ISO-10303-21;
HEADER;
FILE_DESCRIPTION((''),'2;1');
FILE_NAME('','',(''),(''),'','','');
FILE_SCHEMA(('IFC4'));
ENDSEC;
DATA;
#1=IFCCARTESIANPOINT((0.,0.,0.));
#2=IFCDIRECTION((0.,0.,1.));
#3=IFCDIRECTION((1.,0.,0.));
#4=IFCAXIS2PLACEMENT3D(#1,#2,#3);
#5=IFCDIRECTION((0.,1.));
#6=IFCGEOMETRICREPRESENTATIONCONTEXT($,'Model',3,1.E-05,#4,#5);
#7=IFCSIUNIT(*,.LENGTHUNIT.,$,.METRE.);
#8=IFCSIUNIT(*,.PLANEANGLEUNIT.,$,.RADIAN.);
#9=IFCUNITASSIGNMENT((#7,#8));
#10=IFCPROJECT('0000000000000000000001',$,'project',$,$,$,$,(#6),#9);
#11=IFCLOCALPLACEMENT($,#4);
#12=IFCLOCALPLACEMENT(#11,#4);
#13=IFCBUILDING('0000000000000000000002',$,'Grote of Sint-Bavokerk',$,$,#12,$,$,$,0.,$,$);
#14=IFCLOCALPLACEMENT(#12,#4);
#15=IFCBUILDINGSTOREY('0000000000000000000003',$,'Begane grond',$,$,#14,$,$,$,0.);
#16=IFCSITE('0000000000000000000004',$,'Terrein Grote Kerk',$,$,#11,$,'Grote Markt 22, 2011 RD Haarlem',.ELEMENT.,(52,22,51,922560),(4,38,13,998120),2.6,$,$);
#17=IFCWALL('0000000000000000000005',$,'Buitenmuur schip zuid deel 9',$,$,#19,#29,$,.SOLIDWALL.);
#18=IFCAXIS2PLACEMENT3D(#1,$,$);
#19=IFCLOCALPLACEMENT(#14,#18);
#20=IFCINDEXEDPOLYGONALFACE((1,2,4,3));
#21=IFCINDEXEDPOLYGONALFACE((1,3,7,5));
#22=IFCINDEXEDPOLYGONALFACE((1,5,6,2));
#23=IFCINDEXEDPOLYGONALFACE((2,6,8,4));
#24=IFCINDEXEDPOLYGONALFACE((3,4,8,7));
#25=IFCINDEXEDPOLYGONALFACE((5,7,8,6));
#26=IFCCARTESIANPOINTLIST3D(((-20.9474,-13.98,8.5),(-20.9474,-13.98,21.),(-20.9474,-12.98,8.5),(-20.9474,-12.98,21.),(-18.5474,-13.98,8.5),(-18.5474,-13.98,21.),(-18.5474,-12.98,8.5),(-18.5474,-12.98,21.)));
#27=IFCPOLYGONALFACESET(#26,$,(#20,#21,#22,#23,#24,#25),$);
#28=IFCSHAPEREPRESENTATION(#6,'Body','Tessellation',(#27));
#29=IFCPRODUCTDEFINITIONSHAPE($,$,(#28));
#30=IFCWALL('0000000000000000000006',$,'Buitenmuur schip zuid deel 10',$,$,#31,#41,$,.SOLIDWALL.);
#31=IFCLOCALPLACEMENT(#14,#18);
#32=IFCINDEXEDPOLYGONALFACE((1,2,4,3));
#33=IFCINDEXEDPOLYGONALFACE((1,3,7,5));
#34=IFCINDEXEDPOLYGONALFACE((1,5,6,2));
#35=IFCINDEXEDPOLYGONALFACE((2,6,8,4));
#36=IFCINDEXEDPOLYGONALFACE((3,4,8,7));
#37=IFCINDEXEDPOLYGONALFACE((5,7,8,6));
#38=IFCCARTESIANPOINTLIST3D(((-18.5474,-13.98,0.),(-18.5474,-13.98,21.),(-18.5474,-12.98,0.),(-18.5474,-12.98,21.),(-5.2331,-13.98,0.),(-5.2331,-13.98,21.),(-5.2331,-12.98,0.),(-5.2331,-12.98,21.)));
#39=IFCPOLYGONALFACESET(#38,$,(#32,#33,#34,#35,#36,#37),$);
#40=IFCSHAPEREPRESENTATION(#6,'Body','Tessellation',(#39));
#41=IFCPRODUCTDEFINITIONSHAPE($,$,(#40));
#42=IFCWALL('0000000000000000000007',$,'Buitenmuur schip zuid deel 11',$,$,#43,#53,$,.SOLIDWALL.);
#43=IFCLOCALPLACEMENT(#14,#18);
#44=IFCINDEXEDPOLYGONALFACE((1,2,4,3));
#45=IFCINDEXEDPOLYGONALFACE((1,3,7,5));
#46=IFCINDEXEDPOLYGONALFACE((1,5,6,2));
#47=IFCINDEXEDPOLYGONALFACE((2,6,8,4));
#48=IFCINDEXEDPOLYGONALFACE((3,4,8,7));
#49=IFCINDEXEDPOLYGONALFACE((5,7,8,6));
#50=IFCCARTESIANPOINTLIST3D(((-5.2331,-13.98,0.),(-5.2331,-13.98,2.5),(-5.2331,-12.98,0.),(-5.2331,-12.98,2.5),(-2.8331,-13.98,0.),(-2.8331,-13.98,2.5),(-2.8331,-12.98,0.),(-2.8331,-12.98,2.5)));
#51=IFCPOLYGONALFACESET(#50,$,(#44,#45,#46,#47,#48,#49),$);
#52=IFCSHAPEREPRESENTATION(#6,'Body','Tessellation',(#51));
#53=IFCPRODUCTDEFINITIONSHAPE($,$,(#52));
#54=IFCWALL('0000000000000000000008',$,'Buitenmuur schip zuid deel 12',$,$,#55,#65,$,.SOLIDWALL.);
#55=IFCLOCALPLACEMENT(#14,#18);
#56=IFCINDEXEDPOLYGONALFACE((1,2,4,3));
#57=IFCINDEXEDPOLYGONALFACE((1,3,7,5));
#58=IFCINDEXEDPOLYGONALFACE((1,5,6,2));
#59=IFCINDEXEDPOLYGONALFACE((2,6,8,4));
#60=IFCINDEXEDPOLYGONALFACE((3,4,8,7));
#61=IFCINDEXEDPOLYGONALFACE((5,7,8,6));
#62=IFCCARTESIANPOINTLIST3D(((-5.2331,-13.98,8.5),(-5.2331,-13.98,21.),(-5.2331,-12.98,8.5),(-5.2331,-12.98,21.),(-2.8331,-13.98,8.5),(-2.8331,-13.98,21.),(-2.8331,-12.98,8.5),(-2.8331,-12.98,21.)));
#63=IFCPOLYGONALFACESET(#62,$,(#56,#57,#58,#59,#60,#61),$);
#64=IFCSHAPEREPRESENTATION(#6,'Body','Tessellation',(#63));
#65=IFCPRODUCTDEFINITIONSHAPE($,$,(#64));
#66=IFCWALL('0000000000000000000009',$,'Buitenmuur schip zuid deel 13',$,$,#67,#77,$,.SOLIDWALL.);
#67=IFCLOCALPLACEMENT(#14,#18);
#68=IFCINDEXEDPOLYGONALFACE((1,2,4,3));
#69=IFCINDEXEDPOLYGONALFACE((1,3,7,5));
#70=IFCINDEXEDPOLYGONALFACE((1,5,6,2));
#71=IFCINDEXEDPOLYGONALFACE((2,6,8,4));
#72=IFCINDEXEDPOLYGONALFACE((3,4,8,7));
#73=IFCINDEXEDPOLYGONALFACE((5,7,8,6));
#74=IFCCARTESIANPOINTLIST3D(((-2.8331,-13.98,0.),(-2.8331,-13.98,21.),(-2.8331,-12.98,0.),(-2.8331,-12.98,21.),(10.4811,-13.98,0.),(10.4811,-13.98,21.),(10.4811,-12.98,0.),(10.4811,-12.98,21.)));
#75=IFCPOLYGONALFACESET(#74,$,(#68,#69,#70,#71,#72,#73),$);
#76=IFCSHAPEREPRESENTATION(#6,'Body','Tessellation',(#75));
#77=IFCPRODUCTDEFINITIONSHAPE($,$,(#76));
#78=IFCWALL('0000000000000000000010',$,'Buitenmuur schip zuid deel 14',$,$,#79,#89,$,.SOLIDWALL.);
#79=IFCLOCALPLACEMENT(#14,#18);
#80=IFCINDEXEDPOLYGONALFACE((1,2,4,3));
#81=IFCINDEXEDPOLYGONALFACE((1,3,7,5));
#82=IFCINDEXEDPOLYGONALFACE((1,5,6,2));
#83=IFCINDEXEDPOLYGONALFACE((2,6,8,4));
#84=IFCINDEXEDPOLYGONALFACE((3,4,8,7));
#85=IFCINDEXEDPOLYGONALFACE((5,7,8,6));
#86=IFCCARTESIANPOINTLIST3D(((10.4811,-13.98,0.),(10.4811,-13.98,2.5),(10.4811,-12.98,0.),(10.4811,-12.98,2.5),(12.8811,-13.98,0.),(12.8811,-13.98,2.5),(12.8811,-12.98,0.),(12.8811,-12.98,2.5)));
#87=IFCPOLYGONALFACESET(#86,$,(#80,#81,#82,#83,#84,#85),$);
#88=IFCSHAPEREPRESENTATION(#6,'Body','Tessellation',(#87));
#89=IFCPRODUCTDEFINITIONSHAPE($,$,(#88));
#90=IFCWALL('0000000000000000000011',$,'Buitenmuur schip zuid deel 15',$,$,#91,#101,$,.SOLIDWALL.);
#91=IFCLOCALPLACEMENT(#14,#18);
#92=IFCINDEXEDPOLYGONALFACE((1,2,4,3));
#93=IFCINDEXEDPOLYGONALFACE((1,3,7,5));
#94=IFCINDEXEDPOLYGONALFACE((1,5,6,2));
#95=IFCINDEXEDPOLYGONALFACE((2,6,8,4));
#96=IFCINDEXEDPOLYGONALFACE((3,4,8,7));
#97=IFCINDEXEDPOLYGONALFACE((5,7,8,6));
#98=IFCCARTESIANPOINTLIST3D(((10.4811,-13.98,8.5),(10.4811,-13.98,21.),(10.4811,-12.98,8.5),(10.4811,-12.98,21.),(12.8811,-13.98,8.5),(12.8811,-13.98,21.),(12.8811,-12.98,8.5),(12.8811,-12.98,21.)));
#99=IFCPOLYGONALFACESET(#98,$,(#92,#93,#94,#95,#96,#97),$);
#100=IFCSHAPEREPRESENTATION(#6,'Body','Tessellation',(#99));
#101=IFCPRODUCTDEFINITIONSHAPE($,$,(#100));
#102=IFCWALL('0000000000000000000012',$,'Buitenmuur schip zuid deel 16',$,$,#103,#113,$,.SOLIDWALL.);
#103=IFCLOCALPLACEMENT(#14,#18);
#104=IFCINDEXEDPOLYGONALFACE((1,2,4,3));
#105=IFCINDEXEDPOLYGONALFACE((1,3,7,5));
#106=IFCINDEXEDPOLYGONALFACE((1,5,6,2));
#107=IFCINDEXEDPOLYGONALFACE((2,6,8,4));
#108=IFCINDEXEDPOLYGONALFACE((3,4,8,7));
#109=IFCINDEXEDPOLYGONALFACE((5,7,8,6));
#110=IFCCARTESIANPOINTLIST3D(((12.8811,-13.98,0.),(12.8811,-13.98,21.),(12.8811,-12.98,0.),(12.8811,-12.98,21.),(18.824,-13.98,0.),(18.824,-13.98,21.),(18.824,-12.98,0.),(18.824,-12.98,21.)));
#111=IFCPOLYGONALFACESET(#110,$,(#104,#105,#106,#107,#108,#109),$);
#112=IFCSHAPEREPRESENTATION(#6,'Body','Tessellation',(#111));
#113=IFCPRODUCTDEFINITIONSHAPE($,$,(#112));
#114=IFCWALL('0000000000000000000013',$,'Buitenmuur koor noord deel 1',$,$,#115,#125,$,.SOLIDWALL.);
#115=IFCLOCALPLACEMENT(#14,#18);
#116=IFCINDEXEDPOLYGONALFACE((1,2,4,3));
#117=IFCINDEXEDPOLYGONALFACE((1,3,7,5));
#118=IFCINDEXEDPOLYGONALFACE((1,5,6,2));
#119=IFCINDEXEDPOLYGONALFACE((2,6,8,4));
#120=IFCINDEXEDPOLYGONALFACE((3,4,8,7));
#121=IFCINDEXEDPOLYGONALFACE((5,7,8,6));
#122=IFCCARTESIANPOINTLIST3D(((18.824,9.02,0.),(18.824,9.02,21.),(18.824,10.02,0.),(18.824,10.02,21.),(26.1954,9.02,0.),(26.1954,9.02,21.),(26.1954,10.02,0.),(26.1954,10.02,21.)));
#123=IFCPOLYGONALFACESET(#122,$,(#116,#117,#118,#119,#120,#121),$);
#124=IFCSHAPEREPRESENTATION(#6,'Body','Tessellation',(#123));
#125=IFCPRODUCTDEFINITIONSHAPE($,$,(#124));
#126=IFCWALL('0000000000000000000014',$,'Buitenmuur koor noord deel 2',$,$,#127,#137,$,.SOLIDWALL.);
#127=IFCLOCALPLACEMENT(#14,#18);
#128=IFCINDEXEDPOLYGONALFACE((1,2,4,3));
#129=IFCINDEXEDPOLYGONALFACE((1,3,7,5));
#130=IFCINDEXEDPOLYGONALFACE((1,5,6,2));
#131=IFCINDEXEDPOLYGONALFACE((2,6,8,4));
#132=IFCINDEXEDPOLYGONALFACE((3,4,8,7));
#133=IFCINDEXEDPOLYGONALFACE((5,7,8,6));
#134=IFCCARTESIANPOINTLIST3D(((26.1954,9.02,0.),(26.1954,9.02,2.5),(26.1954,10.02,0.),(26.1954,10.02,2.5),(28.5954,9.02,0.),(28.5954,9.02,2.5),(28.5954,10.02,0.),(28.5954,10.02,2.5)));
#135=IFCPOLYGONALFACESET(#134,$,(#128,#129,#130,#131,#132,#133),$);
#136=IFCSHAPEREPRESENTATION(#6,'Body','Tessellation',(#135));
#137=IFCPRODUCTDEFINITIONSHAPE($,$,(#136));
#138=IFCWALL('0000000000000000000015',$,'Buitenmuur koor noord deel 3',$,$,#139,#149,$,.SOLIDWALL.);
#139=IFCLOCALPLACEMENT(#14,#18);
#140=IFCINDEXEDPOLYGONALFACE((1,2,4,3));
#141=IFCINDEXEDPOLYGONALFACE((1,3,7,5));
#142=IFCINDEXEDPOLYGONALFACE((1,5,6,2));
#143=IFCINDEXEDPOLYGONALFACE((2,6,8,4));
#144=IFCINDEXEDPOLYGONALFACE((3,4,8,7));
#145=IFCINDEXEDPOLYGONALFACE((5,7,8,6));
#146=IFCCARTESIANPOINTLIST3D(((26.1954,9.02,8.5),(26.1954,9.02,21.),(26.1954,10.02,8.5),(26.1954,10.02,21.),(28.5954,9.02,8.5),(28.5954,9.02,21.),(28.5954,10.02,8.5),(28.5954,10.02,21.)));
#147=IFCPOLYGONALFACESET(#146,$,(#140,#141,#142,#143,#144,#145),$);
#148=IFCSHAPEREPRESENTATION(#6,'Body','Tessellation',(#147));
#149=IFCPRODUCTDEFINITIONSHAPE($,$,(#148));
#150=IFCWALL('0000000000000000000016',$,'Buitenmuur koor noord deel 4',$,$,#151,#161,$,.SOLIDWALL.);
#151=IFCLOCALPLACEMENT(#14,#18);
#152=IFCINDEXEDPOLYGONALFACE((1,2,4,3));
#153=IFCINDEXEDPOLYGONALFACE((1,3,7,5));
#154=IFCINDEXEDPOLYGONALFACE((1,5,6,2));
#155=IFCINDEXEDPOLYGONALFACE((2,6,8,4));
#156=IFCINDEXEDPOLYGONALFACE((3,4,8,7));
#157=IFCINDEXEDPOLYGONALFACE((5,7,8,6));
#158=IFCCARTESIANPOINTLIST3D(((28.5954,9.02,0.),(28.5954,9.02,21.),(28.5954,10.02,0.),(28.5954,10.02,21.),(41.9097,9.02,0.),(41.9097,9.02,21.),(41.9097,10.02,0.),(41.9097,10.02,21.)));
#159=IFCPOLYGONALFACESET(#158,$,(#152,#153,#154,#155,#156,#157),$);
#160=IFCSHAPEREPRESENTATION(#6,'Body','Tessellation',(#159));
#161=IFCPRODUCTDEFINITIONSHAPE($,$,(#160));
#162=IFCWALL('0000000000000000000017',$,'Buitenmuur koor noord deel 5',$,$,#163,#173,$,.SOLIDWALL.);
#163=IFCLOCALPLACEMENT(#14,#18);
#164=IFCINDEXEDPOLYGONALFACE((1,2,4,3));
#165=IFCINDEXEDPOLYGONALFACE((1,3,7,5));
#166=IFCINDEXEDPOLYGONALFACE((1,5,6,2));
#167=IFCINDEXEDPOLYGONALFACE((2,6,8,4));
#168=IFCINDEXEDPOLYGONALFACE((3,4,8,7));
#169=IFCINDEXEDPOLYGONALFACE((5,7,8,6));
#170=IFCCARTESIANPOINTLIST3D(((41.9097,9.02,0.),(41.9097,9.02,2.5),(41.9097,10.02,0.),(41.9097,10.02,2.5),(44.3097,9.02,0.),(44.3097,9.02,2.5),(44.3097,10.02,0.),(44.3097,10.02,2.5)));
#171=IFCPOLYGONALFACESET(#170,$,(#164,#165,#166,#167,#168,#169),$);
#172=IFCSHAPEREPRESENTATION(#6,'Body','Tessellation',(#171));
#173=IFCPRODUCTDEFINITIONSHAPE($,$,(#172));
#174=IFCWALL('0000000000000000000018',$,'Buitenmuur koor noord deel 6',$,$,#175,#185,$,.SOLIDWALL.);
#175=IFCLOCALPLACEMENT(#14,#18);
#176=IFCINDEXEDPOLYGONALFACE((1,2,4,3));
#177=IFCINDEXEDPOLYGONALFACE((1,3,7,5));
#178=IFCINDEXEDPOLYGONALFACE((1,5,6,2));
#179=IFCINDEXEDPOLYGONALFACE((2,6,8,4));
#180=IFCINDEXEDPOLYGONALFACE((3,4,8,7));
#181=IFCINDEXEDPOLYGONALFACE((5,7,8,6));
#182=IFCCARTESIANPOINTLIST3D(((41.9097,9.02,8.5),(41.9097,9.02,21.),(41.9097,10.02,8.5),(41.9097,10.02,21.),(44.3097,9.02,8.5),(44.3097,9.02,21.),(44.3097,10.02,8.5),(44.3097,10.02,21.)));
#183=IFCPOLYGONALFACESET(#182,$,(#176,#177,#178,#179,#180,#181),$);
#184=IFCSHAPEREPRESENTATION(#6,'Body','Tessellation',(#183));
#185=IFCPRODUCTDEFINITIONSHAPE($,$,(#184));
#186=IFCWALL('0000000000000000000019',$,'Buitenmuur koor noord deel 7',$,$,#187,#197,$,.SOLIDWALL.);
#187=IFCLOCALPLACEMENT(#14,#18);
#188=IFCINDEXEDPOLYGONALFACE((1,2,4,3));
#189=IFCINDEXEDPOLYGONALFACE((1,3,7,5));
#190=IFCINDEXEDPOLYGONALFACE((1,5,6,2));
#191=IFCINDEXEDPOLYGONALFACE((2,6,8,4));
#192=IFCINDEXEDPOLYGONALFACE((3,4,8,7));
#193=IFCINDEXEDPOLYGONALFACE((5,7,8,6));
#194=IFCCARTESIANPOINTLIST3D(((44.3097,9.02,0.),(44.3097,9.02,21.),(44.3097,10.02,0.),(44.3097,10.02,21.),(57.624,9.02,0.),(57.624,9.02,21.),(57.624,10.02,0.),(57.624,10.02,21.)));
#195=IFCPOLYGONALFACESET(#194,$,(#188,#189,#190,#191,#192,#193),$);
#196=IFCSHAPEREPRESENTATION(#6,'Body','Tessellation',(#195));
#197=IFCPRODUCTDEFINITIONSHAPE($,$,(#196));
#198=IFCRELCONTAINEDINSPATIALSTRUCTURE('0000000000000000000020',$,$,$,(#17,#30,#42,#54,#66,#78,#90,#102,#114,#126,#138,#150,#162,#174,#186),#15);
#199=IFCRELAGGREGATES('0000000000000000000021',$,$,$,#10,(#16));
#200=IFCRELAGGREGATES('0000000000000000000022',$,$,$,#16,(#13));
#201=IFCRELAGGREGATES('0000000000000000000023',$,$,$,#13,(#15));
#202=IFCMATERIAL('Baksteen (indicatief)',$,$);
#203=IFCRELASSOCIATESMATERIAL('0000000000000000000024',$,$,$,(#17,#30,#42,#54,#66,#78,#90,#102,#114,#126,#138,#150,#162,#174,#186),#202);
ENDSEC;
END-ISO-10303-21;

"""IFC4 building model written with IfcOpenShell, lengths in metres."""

from ifc_helpers import new_model, si_unit, direction, frame, origin_with_axes, place, context, project, spatial, indexed_curve, outline, extrude, material, element, save


model = new_model("IFC4")

# Units and contexts
model_context = context("Model", 3, precision=1e-05, world=origin_with_axes(), true_north=direction((0.0, 1.0)))
ifc_project = project(units=[si_unit("LENGTHUNIT", "METRE"), si_unit("PLANEANGLEUNIT", "RADIAN")], contexts=[model_context])

# Site, building, storey
site_placement = place(None, origin_with_axes())
site = spatial("IfcSite", under=ifc_project, at=site_placement, Name="Terrein Grote Kerk", LongName="Grote Markt 22, 2011 RD Haarlem", CompositionType="ELEMENT", RefLatitude=(52, 22, 51, 922560), RefLongitude=(4, 38, 13, 998120), RefElevation=2.6)
building_placement = place(site_placement, origin_with_axes())
building = spatial("IfcBuilding", under=site, at=building_placement, Name="Grote of Sint-Bavokerk", ElevationOfRefHeight=0.0)
storey_placement = place(building_placement, origin_with_axes())
storey = spatial("IfcBuildingStorey", under=building, at=storey_placement, Name="Begane grond", Elevation=0.0)

# Walls
ifc_material = material(Name="Baksteen (indicatief)")
wall_1_placement = place(storey_placement, origin_with_axes())
element("IfcWall", 1, at=wall_1_placement, inside=storey, material=ifc_material, Name="Buitenmuur schip zuid deel 9", PredefinedType="SOLIDWALL", context=model_context, shape_type="SweptSolid", body=[
    extrude(outline(indexed_curve([(-20.9474, -13.98), (-18.5474, -13.98), (-18.5474, -12.98), (-20.9474, -12.98), (-20.9474, -13.98)])), frame((0.0, 0.0, 8.5), z_axis=(0.0, 0.0, 1.0), x_axis=(1.0, 0.0, 0.0)), (0.0, 0.0, 1.0), 12.5),
])
wall_2_placement = place(storey_placement, origin_with_axes())
element("IfcWall", 2, at=wall_2_placement, inside=storey, material=ifc_material, Name="Buitenmuur schip zuid deel 10", PredefinedType="SOLIDWALL", context=model_context, shape_type="SweptSolid", body=[
    extrude(outline(indexed_curve([(-18.5474, -13.98), (-5.2331, -13.98), (-5.2331, -12.98), (-18.5474, -12.98), (-18.5474, -13.98)])), origin_with_axes(), (0.0, 0.0, 1.0), 21.0),
])
wall_3_placement = place(storey_placement, origin_with_axes())
element("IfcWall", 3, at=wall_3_placement, inside=storey, material=ifc_material, Name="Buitenmuur schip zuid deel 11", PredefinedType="SOLIDWALL", context=model_context, shape_type="SweptSolid", body=[
    extrude(outline(indexed_curve([(-5.2331, -13.98), (-2.8331, -13.98), (-2.8331, -12.98), (-5.2331, -12.98), (-5.2331, -13.98)])), origin_with_axes(), (0.0, 0.0, 1.0), 2.5),
])
wall_4_placement = place(storey_placement, origin_with_axes())
element("IfcWall", 4, at=wall_4_placement, inside=storey, material=ifc_material, Name="Buitenmuur schip zuid deel 12", PredefinedType="SOLIDWALL", context=model_context, shape_type="SweptSolid", body=[
    extrude(outline(indexed_curve([(-5.2331, -13.98), (-2.8331, -13.98), (-2.8331, -12.98), (-5.2331, -12.98), (-5.2331, -13.98)])), frame((0.0, 0.0, 8.5), z_axis=(0.0, 0.0, 1.0), x_axis=(1.0, 0.0, 0.0)), (0.0, 0.0, 1.0), 12.5),
])
wall_5_placement = place(storey_placement, origin_with_axes())
element("IfcWall", 5, at=wall_5_placement, inside=storey, material=ifc_material, Name="Buitenmuur schip zuid deel 13", PredefinedType="SOLIDWALL", context=model_context, shape_type="SweptSolid", body=[
    extrude(outline(indexed_curve([(-2.8331, -13.98), (10.4811, -13.98), (10.4811, -12.98), (-2.8331, -12.98), (-2.8331, -13.98)])), origin_with_axes(), (0.0, 0.0, 1.0), 21.0),
])
wall_6_placement = place(storey_placement, origin_with_axes())
element("IfcWall", 6, at=wall_6_placement, inside=storey, material=ifc_material, Name="Buitenmuur schip zuid deel 14", PredefinedType="SOLIDWALL", context=model_context, shape_type="SweptSolid", body=[
    extrude(outline(indexed_curve([(10.4811, -13.98), (12.8811, -13.98), (12.8811, -12.98), (10.4811, -12.98), (10.4811, -13.98)])), origin_with_axes(), (0.0, 0.0, 1.0), 2.5),
])
wall_7_placement = place(storey_placement, origin_with_axes())
element("IfcWall", 7, at=wall_7_placement, inside=storey, material=ifc_material, Name="Buitenmuur schip zuid deel 15", PredefinedType="SOLIDWALL", context=model_context, shape_type="SweptSolid", body=[
    extrude(outline(indexed_curve([(10.4811, -13.98), (12.8811, -13.98), (12.8811, -12.98), (10.4811, -12.98), (10.4811, -13.98)])), frame((0.0, 0.0, 8.5), z_axis=(0.0, 0.0, 1.0), x_axis=(1.0, 0.0, 0.0)), (0.0, 0.0, 1.0), 12.5),
])
wall_8_placement = place(storey_placement, origin_with_axes())
element("IfcWall", 8, at=wall_8_placement, inside=storey, material=ifc_material, Name="Buitenmuur schip zuid deel 16", PredefinedType="SOLIDWALL", context=model_context, shape_type="SweptSolid", body=[
    extrude(outline(indexed_curve([(12.8811, -13.98), (18.824, -13.98), (18.824, -12.98), (12.8811, -12.98), (12.8811, -13.98)])), origin_with_axes(), (0.0, 0.0, 1.0), 21.0),
])
wall_9_placement = place(storey_placement, origin_with_axes())
element("IfcWall", 9, at=wall_9_placement, inside=storey, material=ifc_material, Name="Buitenmuur koor noord deel 1", PredefinedType="SOLIDWALL", context=model_context, shape_type="SweptSolid", body=[
    extrude(outline(indexed_curve([(18.824, 9.02), (26.1954, 9.02), (26.1954, 10.02), (18.824, 10.02), (18.824, 9.02)])), origin_with_axes(), (0.0, 0.0, 1.0), 21.0),
])
wall_10_placement = place(storey_placement, origin_with_axes())
element("IfcWall", 10, at=wall_10_placement, inside=storey, material=ifc_material, Name="Buitenmuur koor noord deel 2", PredefinedType="SOLIDWALL", context=model_context, shape_type="SweptSolid", body=[
    extrude(outline(indexed_curve([(26.1954, 9.02), (28.5954, 9.02), (28.5954, 10.02), (26.1954, 10.02), (26.1954, 9.02)])), origin_with_axes(), (0.0, 0.0, 1.0), 2.5),
])
wall_11_placement = place(storey_placement, origin_with_axes())
element("IfcWall", 11, at=wall_11_placement, inside=storey, material=ifc_material, Name="Buitenmuur koor noord deel 3", PredefinedType="SOLIDWALL", context=model_context, shape_type="SweptSolid", body=[
    extrude(outline(indexed_curve([(26.1954, 9.02), (28.5954, 9.02), (28.5954, 10.02), (26.1954, 10.02), (26.1954, 9.02)])), frame((0.0, 0.0, 8.5), z_axis=(0.0, 0.0, 1.0), x_axis=(1.0, 0.0, 0.0)), (0.0, 0.0, 1.0), 12.5),
])
wall_12_placement = place(storey_placement, origin_with_axes())
element("IfcWall", 12, at=wall_12_placement, inside=storey, material=ifc_material, Name="Buitenmuur koor noord deel 4", PredefinedType="SOLIDWALL", context=model_context, shape_type="SweptSolid", body=[
    extrude(outline(indexed_curve([(28.5954, 9.02), (41.9097, 9.02), (41.9097, 10.02), (28.5954, 10.02), (28.5954, 9.02)])), origin_with_axes(), (0.0, 0.0, 1.0), 21.0),
])
wall_13_placement = place(storey_placement, origin_with_axes())
element("IfcWall", 13, at=wall_13_placement, inside=storey, material=ifc_material, Name="Buitenmuur koor noord deel 5", PredefinedType="SOLIDWALL", context=model_context, shape_type="SweptSolid", body=[
    extrude(outline(indexed_curve([(41.9097, 9.02), (44.3097, 9.02), (44.3097, 10.02), (41.9097, 10.02), (41.9097, 9.02)])), origin_with_axes(), (0.0, 0.0, 1.0), 2.5),
])
wall_14_placement = place(storey_placement, origin_with_axes())
element("IfcWall", 14, at=wall_14_placement, inside=storey, material=ifc_material, Name="Buitenmuur koor noord deel 6", PredefinedType="SOLIDWALL", context=model_context, shape_type="SweptSolid", body=[
    extrude(outline(indexed_curve([(41.9097, 9.02), (44.3097, 9.02), (44.3097, 10.02), (41.9097, 10.02), (41.9097, 9.02)])), frame((0.0, 0.0, 8.5), z_axis=(0.0, 0.0, 1.0), x_axis=(1.0, 0.0, 0.0)), (0.0, 0.0, 1.0), 12.5),
])
wall_15_placement = place(storey_placement, origin_with_axes())
element("IfcWall", 15, at=wall_15_placement, inside=storey, material=ifc_material, Name="Buitenmuur koor noord deel 7", PredefinedType="SOLIDWALL", context=model_context, shape_type="SweptSolid", body=[
    extrude(outline(indexed_curve([(44.3097, 9.02), (57.624, 9.02), (57.624, 10.02), (44.3097, 10.02), (44.3097, 9.02)])), origin_with_axes(), (0.0, 0.0, 1.0), 21.0),
])

save(model, "model.ifc")
